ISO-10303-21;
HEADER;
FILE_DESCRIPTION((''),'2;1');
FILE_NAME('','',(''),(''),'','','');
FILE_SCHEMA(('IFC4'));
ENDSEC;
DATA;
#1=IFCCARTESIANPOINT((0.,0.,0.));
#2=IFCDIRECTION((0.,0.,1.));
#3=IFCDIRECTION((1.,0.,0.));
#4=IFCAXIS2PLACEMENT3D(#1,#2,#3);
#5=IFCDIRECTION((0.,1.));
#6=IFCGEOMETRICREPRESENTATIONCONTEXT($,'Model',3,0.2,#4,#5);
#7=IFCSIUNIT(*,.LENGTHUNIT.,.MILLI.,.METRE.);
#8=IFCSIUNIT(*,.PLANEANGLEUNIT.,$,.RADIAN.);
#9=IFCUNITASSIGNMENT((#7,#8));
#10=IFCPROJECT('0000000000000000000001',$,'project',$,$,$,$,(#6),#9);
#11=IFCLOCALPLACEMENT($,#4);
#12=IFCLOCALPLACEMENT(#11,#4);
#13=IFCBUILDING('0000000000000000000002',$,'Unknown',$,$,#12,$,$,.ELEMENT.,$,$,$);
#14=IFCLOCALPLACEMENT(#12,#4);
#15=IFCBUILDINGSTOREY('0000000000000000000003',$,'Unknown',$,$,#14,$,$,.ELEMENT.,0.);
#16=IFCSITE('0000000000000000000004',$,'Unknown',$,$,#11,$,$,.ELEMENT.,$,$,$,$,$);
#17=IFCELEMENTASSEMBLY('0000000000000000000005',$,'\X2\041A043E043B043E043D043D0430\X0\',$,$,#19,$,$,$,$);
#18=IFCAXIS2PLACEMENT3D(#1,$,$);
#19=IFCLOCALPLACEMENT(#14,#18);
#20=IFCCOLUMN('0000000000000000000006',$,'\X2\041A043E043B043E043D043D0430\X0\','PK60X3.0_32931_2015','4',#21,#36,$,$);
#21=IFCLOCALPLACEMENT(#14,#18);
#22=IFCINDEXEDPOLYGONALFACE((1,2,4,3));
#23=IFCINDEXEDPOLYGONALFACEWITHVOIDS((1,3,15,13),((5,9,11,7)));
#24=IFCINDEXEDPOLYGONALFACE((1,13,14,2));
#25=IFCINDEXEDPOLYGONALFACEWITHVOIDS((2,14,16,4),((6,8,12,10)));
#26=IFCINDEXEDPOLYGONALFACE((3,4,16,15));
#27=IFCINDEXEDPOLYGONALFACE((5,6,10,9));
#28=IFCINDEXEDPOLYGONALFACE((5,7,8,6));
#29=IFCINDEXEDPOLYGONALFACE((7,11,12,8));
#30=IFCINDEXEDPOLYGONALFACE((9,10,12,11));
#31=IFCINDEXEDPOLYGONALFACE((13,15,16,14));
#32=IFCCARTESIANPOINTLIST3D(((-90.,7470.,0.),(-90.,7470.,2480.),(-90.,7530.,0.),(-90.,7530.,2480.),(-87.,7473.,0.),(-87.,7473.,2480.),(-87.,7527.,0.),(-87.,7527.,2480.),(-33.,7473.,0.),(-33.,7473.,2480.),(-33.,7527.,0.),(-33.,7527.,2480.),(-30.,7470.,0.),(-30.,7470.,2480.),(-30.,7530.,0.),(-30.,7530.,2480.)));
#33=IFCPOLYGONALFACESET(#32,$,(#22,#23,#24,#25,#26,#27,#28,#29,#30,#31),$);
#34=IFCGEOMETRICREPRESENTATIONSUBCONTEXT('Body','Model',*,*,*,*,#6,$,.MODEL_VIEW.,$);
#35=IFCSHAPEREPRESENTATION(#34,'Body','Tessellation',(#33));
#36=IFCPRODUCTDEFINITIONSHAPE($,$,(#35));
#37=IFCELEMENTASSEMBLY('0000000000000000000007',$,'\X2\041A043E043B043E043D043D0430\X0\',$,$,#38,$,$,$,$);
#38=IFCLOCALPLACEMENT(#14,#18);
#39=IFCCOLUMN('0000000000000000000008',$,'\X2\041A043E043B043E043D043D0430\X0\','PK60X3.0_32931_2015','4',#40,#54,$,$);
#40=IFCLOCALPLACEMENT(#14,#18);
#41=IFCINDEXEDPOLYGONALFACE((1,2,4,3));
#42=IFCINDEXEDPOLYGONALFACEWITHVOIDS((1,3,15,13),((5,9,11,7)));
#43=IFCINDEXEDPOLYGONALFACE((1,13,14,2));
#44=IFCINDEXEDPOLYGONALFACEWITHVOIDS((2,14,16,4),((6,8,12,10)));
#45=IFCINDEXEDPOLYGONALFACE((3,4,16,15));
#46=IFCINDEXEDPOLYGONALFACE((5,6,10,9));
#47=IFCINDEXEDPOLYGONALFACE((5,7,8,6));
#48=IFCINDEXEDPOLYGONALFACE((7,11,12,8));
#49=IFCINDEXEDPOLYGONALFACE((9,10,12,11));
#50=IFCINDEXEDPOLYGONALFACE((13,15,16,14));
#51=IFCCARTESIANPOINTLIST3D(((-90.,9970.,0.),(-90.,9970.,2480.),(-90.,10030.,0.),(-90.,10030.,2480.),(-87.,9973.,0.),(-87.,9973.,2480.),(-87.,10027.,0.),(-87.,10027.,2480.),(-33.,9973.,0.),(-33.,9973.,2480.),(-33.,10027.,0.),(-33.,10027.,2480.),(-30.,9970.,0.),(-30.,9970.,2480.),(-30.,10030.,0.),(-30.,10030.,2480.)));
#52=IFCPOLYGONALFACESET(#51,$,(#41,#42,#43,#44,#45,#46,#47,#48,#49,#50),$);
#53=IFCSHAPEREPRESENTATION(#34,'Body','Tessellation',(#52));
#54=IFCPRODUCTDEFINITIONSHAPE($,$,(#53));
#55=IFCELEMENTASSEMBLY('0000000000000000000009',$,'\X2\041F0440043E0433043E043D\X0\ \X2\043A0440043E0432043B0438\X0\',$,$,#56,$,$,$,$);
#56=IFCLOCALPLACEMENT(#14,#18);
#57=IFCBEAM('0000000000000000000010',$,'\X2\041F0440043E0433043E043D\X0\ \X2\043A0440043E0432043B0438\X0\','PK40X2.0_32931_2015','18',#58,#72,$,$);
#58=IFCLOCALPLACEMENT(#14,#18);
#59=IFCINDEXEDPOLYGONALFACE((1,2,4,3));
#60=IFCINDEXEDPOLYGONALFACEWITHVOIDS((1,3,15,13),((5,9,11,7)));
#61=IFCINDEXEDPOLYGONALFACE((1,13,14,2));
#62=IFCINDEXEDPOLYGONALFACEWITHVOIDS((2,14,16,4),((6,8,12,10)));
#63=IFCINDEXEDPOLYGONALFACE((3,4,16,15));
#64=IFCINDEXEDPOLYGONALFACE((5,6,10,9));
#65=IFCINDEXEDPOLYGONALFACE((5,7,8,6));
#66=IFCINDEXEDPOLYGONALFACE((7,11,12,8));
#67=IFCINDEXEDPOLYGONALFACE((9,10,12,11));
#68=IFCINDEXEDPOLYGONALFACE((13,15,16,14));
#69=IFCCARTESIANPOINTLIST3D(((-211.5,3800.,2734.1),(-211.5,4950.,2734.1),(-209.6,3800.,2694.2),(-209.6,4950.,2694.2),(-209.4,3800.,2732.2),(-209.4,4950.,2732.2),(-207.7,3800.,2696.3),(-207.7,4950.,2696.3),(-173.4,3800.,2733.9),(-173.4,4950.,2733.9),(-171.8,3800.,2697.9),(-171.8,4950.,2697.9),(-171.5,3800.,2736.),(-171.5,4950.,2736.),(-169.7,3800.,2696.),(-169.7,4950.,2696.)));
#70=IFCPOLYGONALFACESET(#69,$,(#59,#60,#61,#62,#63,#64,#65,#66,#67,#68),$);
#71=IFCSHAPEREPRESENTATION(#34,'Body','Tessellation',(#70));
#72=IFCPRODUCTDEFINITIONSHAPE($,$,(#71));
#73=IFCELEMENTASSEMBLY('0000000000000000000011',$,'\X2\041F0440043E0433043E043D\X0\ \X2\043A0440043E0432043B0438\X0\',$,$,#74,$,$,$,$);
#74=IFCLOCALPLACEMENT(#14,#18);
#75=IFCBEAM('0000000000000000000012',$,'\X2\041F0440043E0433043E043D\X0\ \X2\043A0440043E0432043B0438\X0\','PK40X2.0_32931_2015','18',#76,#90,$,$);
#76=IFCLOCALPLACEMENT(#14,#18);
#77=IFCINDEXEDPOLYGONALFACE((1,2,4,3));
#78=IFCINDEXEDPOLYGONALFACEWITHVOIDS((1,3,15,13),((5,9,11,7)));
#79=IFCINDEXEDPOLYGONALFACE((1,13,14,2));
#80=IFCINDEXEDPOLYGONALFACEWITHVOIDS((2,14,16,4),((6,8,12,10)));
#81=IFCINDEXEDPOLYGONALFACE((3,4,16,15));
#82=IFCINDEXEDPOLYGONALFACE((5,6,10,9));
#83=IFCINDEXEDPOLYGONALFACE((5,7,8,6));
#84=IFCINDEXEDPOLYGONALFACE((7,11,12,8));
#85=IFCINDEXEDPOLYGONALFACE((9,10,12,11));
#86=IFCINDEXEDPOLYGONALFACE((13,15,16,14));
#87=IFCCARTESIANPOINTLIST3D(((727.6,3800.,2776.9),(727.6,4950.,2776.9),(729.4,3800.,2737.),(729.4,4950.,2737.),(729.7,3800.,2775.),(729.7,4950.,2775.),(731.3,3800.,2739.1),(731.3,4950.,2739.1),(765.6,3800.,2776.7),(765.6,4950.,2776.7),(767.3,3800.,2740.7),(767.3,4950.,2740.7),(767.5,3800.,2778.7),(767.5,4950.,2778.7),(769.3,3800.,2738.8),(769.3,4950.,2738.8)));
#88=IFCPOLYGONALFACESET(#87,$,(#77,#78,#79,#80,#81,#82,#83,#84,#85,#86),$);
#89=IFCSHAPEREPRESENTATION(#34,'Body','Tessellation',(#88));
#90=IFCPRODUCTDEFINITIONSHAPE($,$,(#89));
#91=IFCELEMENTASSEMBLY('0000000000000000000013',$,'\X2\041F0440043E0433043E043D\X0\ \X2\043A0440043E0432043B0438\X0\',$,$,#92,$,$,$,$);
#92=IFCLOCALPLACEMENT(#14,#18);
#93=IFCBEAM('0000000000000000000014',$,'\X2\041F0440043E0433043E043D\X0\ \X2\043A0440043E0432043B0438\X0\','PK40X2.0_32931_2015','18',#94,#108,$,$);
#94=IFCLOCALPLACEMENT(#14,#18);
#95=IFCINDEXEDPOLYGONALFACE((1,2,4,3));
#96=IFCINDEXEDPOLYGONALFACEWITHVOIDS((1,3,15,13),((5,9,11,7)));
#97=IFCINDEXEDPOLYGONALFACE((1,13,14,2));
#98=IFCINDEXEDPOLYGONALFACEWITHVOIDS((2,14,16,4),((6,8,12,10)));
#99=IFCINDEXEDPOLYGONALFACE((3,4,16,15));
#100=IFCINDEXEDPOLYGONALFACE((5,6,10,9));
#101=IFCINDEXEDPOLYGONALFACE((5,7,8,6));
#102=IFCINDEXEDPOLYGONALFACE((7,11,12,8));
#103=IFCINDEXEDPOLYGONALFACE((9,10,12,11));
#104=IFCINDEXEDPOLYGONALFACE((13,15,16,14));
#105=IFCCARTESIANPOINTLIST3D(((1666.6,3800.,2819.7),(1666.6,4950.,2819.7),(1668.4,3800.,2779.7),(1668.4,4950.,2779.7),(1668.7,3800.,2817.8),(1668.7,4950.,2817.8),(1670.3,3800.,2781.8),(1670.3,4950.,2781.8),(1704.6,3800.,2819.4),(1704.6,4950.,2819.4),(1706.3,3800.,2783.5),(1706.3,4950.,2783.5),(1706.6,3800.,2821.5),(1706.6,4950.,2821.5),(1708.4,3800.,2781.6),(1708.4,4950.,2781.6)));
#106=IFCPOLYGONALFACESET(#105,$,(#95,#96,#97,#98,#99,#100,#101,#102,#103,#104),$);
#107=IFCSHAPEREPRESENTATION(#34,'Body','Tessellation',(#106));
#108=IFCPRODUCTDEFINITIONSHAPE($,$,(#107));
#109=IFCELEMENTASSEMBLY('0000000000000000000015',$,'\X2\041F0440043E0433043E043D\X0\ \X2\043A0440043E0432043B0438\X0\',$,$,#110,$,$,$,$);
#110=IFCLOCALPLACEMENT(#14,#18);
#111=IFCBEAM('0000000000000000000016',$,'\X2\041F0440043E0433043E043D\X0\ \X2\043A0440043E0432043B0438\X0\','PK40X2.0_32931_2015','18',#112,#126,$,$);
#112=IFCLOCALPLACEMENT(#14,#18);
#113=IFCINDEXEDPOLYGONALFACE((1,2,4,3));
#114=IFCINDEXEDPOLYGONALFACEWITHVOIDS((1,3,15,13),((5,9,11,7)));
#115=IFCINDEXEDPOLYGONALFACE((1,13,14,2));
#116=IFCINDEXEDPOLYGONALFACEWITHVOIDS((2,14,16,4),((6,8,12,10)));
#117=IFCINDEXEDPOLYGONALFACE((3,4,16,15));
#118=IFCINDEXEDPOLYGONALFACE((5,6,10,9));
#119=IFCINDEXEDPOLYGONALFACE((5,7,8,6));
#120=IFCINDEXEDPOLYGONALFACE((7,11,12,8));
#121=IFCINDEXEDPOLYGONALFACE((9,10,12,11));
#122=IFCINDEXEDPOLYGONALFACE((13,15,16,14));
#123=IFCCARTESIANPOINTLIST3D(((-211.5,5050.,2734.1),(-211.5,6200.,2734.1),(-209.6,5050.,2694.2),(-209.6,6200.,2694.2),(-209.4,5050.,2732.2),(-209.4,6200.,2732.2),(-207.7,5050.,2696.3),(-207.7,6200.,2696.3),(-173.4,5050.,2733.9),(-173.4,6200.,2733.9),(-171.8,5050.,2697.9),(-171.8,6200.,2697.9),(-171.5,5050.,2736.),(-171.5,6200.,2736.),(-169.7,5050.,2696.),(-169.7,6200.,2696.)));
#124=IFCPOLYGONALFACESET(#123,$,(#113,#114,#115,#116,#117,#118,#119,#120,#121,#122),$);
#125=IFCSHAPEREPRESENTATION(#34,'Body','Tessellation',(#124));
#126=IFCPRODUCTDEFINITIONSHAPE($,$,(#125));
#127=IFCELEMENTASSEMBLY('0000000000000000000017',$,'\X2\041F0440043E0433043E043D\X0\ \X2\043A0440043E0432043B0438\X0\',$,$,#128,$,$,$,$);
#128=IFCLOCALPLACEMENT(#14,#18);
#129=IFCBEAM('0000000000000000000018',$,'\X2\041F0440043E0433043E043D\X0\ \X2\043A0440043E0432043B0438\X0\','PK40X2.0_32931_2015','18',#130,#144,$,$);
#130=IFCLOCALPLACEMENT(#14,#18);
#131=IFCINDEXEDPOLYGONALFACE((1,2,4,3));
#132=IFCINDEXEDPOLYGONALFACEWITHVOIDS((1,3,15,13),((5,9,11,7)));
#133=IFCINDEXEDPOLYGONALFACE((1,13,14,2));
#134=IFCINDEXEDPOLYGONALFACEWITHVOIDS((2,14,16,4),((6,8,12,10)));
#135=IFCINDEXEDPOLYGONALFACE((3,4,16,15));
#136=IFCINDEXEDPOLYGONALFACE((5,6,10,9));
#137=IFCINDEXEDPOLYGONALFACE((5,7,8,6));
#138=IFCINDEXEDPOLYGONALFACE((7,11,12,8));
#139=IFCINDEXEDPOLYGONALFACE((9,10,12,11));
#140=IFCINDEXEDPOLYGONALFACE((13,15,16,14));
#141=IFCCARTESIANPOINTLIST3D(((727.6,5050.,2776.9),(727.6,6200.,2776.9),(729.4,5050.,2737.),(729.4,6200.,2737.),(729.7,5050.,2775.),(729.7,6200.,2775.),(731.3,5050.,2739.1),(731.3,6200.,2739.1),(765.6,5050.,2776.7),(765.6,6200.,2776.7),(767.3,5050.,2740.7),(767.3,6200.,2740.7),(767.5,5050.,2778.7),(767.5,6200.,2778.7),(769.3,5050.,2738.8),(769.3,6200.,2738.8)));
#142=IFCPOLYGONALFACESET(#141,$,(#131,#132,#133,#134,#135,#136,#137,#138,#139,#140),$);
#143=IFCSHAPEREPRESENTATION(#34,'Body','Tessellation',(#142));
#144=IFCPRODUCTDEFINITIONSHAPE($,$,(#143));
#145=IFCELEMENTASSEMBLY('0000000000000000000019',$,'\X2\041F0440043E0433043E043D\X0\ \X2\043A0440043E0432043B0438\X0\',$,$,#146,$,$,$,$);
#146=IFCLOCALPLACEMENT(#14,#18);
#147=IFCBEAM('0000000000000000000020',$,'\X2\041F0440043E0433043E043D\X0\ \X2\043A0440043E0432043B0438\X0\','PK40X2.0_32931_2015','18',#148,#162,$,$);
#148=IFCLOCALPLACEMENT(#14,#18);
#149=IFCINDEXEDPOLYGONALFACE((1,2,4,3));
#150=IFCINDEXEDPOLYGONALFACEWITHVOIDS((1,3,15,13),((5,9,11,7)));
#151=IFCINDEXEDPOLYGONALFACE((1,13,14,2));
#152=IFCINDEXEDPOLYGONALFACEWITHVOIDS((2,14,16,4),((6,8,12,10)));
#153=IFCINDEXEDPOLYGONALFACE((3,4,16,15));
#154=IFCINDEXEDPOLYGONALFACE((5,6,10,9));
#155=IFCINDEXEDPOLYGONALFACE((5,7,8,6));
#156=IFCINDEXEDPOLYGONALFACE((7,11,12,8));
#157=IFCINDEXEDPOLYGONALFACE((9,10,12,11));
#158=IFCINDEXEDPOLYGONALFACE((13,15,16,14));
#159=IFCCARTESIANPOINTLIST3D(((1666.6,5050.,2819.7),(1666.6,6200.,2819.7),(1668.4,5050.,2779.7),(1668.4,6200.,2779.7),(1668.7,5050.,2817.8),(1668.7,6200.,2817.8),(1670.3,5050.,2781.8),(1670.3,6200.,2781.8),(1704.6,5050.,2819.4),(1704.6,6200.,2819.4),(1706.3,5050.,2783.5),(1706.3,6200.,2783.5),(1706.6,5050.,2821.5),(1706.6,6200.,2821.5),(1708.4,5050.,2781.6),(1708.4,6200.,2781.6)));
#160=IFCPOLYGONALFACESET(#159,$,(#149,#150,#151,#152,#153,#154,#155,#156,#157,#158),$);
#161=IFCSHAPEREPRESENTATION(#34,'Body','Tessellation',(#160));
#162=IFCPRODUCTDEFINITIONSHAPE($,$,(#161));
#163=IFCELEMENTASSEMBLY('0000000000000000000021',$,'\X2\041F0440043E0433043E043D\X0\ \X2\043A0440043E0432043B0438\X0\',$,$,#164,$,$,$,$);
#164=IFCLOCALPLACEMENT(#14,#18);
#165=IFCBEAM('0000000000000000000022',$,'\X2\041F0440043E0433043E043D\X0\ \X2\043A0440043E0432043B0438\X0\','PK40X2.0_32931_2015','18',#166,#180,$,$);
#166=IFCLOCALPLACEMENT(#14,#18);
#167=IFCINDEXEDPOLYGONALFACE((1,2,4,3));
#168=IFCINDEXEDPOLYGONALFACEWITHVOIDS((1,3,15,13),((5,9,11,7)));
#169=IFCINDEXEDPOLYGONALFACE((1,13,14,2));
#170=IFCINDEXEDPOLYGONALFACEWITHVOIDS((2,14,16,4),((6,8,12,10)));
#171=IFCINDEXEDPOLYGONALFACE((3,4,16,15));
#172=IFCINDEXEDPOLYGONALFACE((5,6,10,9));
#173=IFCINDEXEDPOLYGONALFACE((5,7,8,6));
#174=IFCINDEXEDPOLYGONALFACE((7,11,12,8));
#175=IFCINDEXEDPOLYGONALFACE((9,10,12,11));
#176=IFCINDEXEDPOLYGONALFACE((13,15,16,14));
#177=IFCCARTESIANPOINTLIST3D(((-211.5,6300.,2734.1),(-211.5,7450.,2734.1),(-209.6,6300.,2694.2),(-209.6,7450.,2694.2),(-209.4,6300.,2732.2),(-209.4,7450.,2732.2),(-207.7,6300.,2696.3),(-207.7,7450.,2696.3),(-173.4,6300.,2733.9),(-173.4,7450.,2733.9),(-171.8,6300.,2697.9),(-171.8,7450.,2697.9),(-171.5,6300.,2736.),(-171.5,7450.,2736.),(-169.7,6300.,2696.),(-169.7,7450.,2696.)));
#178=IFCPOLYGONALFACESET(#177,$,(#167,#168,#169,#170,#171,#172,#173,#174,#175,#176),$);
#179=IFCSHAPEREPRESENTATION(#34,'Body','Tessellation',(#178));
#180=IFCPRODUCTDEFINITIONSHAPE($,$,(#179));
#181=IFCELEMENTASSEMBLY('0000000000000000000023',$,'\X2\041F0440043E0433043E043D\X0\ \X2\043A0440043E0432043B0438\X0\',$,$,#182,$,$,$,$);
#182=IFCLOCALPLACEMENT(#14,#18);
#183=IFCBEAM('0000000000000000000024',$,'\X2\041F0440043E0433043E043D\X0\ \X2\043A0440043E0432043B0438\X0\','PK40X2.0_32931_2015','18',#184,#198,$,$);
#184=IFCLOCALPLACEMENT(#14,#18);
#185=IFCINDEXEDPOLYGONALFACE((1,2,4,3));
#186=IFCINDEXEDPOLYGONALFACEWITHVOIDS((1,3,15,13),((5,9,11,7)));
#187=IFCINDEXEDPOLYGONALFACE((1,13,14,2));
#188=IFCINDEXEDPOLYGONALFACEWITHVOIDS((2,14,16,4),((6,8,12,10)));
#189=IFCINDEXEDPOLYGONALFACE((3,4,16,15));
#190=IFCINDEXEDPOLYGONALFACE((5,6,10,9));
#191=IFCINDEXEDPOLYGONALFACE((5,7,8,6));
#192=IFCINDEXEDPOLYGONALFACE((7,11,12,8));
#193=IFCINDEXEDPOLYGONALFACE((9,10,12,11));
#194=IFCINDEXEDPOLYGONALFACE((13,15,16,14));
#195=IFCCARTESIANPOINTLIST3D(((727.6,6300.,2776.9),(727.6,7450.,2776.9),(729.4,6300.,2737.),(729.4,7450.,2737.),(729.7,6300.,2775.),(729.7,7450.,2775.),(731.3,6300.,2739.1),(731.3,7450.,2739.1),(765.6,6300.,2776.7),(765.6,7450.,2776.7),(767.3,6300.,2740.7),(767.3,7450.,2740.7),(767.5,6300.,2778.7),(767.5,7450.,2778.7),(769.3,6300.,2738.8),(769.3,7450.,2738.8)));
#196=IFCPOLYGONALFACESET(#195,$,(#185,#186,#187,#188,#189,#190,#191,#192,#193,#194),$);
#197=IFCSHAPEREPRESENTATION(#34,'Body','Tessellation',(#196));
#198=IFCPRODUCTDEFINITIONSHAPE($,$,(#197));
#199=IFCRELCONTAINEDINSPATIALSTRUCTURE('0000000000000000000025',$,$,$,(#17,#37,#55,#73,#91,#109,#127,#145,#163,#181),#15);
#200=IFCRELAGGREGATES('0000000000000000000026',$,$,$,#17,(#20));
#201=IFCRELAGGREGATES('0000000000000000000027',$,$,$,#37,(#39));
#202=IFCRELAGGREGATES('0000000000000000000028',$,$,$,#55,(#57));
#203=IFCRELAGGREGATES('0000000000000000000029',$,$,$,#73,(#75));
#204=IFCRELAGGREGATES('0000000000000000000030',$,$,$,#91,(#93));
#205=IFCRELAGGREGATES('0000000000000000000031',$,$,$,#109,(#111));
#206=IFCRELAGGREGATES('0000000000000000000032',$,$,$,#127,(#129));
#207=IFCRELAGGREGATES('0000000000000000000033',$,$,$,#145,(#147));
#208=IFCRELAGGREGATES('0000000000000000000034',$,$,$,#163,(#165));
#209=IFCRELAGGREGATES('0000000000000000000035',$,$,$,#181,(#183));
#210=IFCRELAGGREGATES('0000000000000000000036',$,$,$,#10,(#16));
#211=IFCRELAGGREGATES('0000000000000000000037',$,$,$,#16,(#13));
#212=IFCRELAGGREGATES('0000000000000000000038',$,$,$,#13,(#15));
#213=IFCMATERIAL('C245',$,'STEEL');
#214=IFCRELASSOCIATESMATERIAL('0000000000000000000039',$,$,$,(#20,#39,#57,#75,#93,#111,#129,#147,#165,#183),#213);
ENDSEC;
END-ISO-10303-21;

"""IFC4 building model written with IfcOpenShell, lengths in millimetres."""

from ifc_helpers import new_model, si_unit, direction, frame, origin_with_axes, place, context, subcontext, project, spatial, line, indexed_curve, outline, extrude, material, element, aggregate, save


model = new_model("IFC4")

# Units and contexts
model_context = context("Model", 3, precision=0.2, world=origin_with_axes(), true_north=direction((0.0, 1.0)))
body_context = subcontext(model_context, "Body", "Model", "MODEL_VIEW")
ifc_project = project(units=[si_unit("LENGTHUNIT", "METRE", prefix="MILLI"), si_unit("PLANEANGLEUNIT", "RADIAN")], contexts=[model_context])

# Site, building, storey
site_placement = place(None, origin_with_axes())
site = spatial("IfcSite", under=ifc_project, at=site_placement, Name="Unknown", CompositionType="ELEMENT")
building_placement = place(site_placement, origin_with_axes())
building = spatial("IfcBuilding", under=site, at=building_placement, Name="Unknown", CompositionType="ELEMENT")
storey_placement = place(building_placement, origin_with_axes())
storey = spatial("IfcBuildingStorey", under=building, at=storey_placement, Name="Unknown", CompositionType="ELEMENT", Elevation=0.0)

# Shared definitions
ifc_material = material(Name="C245", Category="STEEL")

# Element assemblies, columns
assembly_1_placement = place(storey_placement, frame((-60.0, 7500.0, 0.0), z_axis=(-1.0, 0.0, 0.0), x_axis=(0.0, 0.0, 1.0)))
assembly_1 = element("IfcElementAssembly", 1, at=assembly_1_placement, inside=storey, Name="Колонна")
column_1_placement = place(assembly_1_placement, origin_with_axes())
column_1 = element("IfcColumn", 2, at=column_1_placement, material=ifc_material, Name="Колонна", Description="PK60X3.0_32931_2015", ObjectType="4", context=body_context, shape_type="SolidModel", body=[
    extrude(outline(indexed_curve([(-30.0, -30.0), (30.0, -30.0), (30.0, 30.0), (-30.0, 30.0)], segments=[line(1, 2, 3, 4, 1)]), holes=[indexed_curve([(-27.0, -27.0), (-27.0, 27.0), (27.0, 27.0), (27.0, -27.0)], segments=[line(1, 2, 3, 4, 1)])]), frame((0.0, 0.0, 0.0), z_axis=(-1.0, 0.0, 0.0), x_axis=(0.0, 0.0, 1.0)), (0.0, 0.0, -1.0), 2480.0),
])
aggregate(assembly_1, [column_1])
assembly_2_placement = place(storey_placement, frame((-60.0, 10000.0, 0.0), z_axis=(-1.0, 0.0, 0.0), x_axis=(0.0, 0.0, 1.0)))
assembly_2 = element("IfcElementAssembly", 3, at=assembly_2_placement, inside=storey, Name="Колонна")
column_2_placement = place(assembly_2_placement, origin_with_axes())
column_2 = element("IfcColumn", 4, at=column_2_placement, material=ifc_material, Name="Колонна", Description="PK60X3.0_32931_2015", ObjectType="4", context=body_context, shape_type="SolidModel", body=[
    extrude(outline(indexed_curve([(-30.0, -30.0), (30.0, -30.0), (30.0, 30.0), (-30.0, 30.0)], segments=[line(1, 2, 3, 4, 1)]), holes=[indexed_curve([(-27.0, -27.0), (-27.0, 27.0), (27.0, 27.0), (27.0, -27.0)], segments=[line(1, 2, 3, 4, 1)])]), frame((0.0, 0.0, 0.0), z_axis=(-1.0, 0.0, 0.0), x_axis=(0.0, 0.0, 1.0)), (0.0, 0.0, -1.0), 2480.0),
])
aggregate(assembly_2, [column_2])

# Element assemblies, beams
assembly_3_placement = place(storey_placement, frame((-190.6, 4950.0, 2715.1), z_axis=(-0.998964, 0.0, -0.045508), x_axis=(0.0, -1.0, 0.0)))
assembly_3 = element("IfcElementAssembly", 5, at=assembly_3_placement, inside=storey, Name="Прогон кровли")
beam_1_placement = place(assembly_3_placement, origin_with_axes())
beam_1 = element("IfcBeam", 6, at=beam_1_placement, material=ifc_material, Name="Прогон кровли", Description="PK40X2.0_32931_2015", ObjectType="18", context=body_context, shape_type="SolidModel", body=[
    extrude(outline(indexed_curve([(-20.0, -20.0), (20.0, -20.0), (20.0, 20.0), (-20.0, 20.0)], segments=[line(1, 2, 3, 4, 1)]), holes=[indexed_curve([(-18.0, -18.0), (-18.0, 18.0), (18.0, 18.0), (18.0, -18.0)], segments=[line(1, 2, 3, 4, 1)])]), frame((0.0, 0.0, 0.0), z_axis=(-1.0, 0.0, 0.0), x_axis=(0.0, 0.0, 1.0)), (0.0, 0.0, -1.0), 1150.0),
])
aggregate(assembly_3, [beam_1])
assembly_4_placement = place(storey_placement, frame((748.5, 4950.0, 2757.9), z_axis=(-0.998964, 0.0, -0.045508), x_axis=(0.0, -1.0, 0.0)))
assembly_4 = element("IfcElementAssembly", 7, at=assembly_4_placement, inside=storey, Name="Прогон кровли")
beam_2_placement = place(assembly_4_placement, origin_with_axes())
beam_2 = element("IfcBeam", 8, at=beam_2_placement, material=ifc_material, Name="Прогон кровли", Description="PK40X2.0_32931_2015", ObjectType="18", context=body_context, shape_type="SolidModel", body=[
    extrude(outline(indexed_curve([(-20.0, -20.0), (20.0, -20.0), (20.0, 20.0), (-20.0, 20.0)], segments=[line(1, 2, 3, 4, 1)]), holes=[indexed_curve([(-18.0, -18.0), (-18.0, 18.0), (18.0, 18.0), (18.0, -18.0)], segments=[line(1, 2, 3, 4, 1)])]), frame((0.0, 0.0, 0.0), z_axis=(-1.0, 0.0, 0.0), x_axis=(0.0, 0.0, 1.0)), (0.0, 0.0, -1.0), 1150.0),
])
aggregate(assembly_4, [beam_2])
assembly_5_placement = place(storey_placement, frame((1687.5, 4950.0, 2800.6), z_axis=(-0.998964, 0.0, -0.045508), x_axis=(0.0, -1.0, 0.0)))
assembly_5 = element("IfcElementAssembly", 9, at=assembly_5_placement, inside=storey, Name="Прогон кровли")
beam_3_placement = place(assembly_5_placement, origin_with_axes())
beam_3 = element("IfcBeam", 10, at=beam_3_placement, material=ifc_material, Name="Прогон кровли", Description="PK40X2.0_32931_2015", ObjectType="18", context=body_context, shape_type="SolidModel", body=[
    extrude(outline(indexed_curve([(-20.0, -20.0), (20.0, -20.0), (20.0, 20.0), (-20.0, 20.0)], segments=[line(1, 2, 3, 4, 1)]), holes=[indexed_curve([(-18.0, -18.0), (-18.0, 18.0), (18.0, 18.0), (18.0, -18.0)], segments=[line(1, 2, 3, 4, 1)])]), frame((0.0, 0.0, 0.0), z_axis=(-1.0, 0.0, 0.0), x_axis=(0.0, 0.0, 1.0)), (0.0, 0.0, -1.0), 1150.0),
])
aggregate(assembly_5, [beam_3])
assembly_6_placement = place(storey_placement, frame((-190.6, 6200.0, 2715.1), z_axis=(-0.998964, 0.0, -0.045508), x_axis=(0.0, -1.0, 0.0)))
assembly_6 = element("IfcElementAssembly", 11, at=assembly_6_placement, inside=storey, Name="Прогон кровли")
beam_4_placement = place(assembly_6_placement, origin_with_axes())
beam_4 = element("IfcBeam", 12, at=beam_4_placement, material=ifc_material, Name="Прогон кровли", Description="PK40X2.0_32931_2015", ObjectType="18", context=body_context, shape_type="SolidModel", body=[
    extrude(outline(indexed_curve([(-20.0, -20.0), (20.0, -20.0), (20.0, 20.0), (-20.0, 20.0)], segments=[line(1, 2, 3, 4, 1)]), holes=[indexed_curve([(-18.0, -18.0), (-18.0, 18.0), (18.0, 18.0), (18.0, -18.0)], segments=[line(1, 2, 3, 4, 1)])]), frame((0.0, 0.0, 0.0), z_axis=(-1.0, 0.0, 0.0), x_axis=(0.0, 0.0, 1.0)), (0.0, 0.0, -1.0), 1150.0),
])
aggregate(assembly_6, [beam_4])
assembly_7_placement = place(storey_placement, frame((748.5, 6200.0, 2757.9), z_axis=(-0.998964, 0.0, -0.045508), x_axis=(0.0, -1.0, 0.0)))
assembly_7 = element("IfcElementAssembly", 13, at=assembly_7_placement, inside=storey, Name="Прогон кровли")
beam_5_placement = place(assembly_7_placement, origin_with_axes())
beam_5 = element("IfcBeam", 14, at=beam_5_placement, material=ifc_material, Name="Прогон кровли", Description="PK40X2.0_32931_2015", ObjectType="18", context=body_context, shape_type="SolidModel", body=[
    extrude(outline(indexed_curve([(-20.0, -20.0), (20.0, -20.0), (20.0, 20.0), (-20.0, 20.0)], segments=[line(1, 2, 3, 4, 1)]), holes=[indexed_curve([(-18.0, -18.0), (-18.0, 18.0), (18.0, 18.0), (18.0, -18.0)], segments=[line(1, 2, 3, 4, 1)])]), frame((0.0, 0.0, 0.0), z_axis=(-1.0, 0.0, 0.0), x_axis=(0.0, 0.0, 1.0)), (0.0, 0.0, -1.0), 1150.0),
])
aggregate(assembly_7, [beam_5])
assembly_8_placement = place(storey_placement, frame((1687.5, 6200.0, 2800.6), z_axis=(-0.998964, 0.0, -0.045508), x_axis=(0.0, -1.0, 0.0)))
assembly_8 = element("IfcElementAssembly", 15, at=assembly_8_placement, inside=storey, Name="Прогон кровли")
beam_6_placement = place(assembly_8_placement, origin_with_axes())
beam_6 = element("IfcBeam", 16, at=beam_6_placement, material=ifc_material, Name="Прогон кровли", Description="PK40X2.0_32931_2015", ObjectType="18", context=body_context, shape_type="SolidModel", body=[
    extrude(outline(indexed_curve([(-20.0, -20.0), (20.0, -20.0), (20.0, 20.0), (-20.0, 20.0)], segments=[line(1, 2, 3, 4, 1)]), holes=[indexed_curve([(-18.0, -18.0), (-18.0, 18.0), (18.0, 18.0), (18.0, -18.0)], segments=[line(1, 2, 3, 4, 1)])]), frame((0.0, 0.0, 0.0), z_axis=(-1.0, 0.0, 0.0), x_axis=(0.0, 0.0, 1.0)), (0.0, 0.0, -1.0), 1150.0),
])
aggregate(assembly_8, [beam_6])
assembly_9_placement = place(storey_placement, frame((-190.6, 7450.0, 2715.1), z_axis=(-0.998964, 0.0, -0.045508), x_axis=(0.0, -1.0, 0.0)))
assembly_9 = element("IfcElementAssembly", 17, at=assembly_9_placement, inside=storey, Name="Прогон кровли")
beam_7_placement = place(assembly_9_placement, origin_with_axes())
beam_7 = element("IfcBeam", 18, at=beam_7_placement, material=ifc_material, Name="Прогон кровли", Description="PK40X2.0_32931_2015", ObjectType="18", context=body_context, shape_type="SolidModel", body=[
    extrude(outline(indexed_curve([(-20.0, -20.0), (20.0, -20.0), (20.0, 20.0), (-20.0, 20.0)], segments=[line(1, 2, 3, 4, 1)]), holes=[indexed_curve([(-18.0, -18.0), (-18.0, 18.0), (18.0, 18.0), (18.0, -18.0)], segments=[line(1, 2, 3, 4, 1)])]), frame((0.0, 0.0, 0.0), z_axis=(-1.0, 0.0, 0.0), x_axis=(0.0, 0.0, 1.0)), (0.0, 0.0, -1.0), 1150.0),
])
aggregate(assembly_9, [beam_7])
assembly_10_placement = place(storey_placement, frame((748.5, 7450.0, 2757.9), z_axis=(-0.998964, 0.0, -0.045508), x_axis=(0.0, -1.0, 0.0)))
assembly_10 = element("IfcElementAssembly", 19, at=assembly_10_placement, inside=storey, Name="Прогон кровли")
beam_8_placement = place(assembly_10_placement, origin_with_axes())
beam_8 = element("IfcBeam", 20, at=beam_8_placement, material=ifc_material, Name="Прогон кровли", Description="PK40X2.0_32931_2015", ObjectType="18", context=body_context, shape_type="SolidModel", body=[
    extrude(outline(indexed_curve([(-20.0, -20.0), (20.0, -20.0), (20.0, 20.0), (-20.0, 20.0)], segments=[line(1, 2, 3, 4, 1)]), holes=[indexed_curve([(-18.0, -18.0), (-18.0, 18.0), (18.0, 18.0), (18.0, -18.0)], segments=[line(1, 2, 3, 4, 1)])]), frame((0.0, 0.0, 0.0), z_axis=(-1.0, 0.0, 0.0), x_axis=(0.0, 0.0, 1.0)), (0.0, 0.0, -1.0), 1150.0),
])
aggregate(assembly_10, [beam_8])

save(model, "model.ifc")
